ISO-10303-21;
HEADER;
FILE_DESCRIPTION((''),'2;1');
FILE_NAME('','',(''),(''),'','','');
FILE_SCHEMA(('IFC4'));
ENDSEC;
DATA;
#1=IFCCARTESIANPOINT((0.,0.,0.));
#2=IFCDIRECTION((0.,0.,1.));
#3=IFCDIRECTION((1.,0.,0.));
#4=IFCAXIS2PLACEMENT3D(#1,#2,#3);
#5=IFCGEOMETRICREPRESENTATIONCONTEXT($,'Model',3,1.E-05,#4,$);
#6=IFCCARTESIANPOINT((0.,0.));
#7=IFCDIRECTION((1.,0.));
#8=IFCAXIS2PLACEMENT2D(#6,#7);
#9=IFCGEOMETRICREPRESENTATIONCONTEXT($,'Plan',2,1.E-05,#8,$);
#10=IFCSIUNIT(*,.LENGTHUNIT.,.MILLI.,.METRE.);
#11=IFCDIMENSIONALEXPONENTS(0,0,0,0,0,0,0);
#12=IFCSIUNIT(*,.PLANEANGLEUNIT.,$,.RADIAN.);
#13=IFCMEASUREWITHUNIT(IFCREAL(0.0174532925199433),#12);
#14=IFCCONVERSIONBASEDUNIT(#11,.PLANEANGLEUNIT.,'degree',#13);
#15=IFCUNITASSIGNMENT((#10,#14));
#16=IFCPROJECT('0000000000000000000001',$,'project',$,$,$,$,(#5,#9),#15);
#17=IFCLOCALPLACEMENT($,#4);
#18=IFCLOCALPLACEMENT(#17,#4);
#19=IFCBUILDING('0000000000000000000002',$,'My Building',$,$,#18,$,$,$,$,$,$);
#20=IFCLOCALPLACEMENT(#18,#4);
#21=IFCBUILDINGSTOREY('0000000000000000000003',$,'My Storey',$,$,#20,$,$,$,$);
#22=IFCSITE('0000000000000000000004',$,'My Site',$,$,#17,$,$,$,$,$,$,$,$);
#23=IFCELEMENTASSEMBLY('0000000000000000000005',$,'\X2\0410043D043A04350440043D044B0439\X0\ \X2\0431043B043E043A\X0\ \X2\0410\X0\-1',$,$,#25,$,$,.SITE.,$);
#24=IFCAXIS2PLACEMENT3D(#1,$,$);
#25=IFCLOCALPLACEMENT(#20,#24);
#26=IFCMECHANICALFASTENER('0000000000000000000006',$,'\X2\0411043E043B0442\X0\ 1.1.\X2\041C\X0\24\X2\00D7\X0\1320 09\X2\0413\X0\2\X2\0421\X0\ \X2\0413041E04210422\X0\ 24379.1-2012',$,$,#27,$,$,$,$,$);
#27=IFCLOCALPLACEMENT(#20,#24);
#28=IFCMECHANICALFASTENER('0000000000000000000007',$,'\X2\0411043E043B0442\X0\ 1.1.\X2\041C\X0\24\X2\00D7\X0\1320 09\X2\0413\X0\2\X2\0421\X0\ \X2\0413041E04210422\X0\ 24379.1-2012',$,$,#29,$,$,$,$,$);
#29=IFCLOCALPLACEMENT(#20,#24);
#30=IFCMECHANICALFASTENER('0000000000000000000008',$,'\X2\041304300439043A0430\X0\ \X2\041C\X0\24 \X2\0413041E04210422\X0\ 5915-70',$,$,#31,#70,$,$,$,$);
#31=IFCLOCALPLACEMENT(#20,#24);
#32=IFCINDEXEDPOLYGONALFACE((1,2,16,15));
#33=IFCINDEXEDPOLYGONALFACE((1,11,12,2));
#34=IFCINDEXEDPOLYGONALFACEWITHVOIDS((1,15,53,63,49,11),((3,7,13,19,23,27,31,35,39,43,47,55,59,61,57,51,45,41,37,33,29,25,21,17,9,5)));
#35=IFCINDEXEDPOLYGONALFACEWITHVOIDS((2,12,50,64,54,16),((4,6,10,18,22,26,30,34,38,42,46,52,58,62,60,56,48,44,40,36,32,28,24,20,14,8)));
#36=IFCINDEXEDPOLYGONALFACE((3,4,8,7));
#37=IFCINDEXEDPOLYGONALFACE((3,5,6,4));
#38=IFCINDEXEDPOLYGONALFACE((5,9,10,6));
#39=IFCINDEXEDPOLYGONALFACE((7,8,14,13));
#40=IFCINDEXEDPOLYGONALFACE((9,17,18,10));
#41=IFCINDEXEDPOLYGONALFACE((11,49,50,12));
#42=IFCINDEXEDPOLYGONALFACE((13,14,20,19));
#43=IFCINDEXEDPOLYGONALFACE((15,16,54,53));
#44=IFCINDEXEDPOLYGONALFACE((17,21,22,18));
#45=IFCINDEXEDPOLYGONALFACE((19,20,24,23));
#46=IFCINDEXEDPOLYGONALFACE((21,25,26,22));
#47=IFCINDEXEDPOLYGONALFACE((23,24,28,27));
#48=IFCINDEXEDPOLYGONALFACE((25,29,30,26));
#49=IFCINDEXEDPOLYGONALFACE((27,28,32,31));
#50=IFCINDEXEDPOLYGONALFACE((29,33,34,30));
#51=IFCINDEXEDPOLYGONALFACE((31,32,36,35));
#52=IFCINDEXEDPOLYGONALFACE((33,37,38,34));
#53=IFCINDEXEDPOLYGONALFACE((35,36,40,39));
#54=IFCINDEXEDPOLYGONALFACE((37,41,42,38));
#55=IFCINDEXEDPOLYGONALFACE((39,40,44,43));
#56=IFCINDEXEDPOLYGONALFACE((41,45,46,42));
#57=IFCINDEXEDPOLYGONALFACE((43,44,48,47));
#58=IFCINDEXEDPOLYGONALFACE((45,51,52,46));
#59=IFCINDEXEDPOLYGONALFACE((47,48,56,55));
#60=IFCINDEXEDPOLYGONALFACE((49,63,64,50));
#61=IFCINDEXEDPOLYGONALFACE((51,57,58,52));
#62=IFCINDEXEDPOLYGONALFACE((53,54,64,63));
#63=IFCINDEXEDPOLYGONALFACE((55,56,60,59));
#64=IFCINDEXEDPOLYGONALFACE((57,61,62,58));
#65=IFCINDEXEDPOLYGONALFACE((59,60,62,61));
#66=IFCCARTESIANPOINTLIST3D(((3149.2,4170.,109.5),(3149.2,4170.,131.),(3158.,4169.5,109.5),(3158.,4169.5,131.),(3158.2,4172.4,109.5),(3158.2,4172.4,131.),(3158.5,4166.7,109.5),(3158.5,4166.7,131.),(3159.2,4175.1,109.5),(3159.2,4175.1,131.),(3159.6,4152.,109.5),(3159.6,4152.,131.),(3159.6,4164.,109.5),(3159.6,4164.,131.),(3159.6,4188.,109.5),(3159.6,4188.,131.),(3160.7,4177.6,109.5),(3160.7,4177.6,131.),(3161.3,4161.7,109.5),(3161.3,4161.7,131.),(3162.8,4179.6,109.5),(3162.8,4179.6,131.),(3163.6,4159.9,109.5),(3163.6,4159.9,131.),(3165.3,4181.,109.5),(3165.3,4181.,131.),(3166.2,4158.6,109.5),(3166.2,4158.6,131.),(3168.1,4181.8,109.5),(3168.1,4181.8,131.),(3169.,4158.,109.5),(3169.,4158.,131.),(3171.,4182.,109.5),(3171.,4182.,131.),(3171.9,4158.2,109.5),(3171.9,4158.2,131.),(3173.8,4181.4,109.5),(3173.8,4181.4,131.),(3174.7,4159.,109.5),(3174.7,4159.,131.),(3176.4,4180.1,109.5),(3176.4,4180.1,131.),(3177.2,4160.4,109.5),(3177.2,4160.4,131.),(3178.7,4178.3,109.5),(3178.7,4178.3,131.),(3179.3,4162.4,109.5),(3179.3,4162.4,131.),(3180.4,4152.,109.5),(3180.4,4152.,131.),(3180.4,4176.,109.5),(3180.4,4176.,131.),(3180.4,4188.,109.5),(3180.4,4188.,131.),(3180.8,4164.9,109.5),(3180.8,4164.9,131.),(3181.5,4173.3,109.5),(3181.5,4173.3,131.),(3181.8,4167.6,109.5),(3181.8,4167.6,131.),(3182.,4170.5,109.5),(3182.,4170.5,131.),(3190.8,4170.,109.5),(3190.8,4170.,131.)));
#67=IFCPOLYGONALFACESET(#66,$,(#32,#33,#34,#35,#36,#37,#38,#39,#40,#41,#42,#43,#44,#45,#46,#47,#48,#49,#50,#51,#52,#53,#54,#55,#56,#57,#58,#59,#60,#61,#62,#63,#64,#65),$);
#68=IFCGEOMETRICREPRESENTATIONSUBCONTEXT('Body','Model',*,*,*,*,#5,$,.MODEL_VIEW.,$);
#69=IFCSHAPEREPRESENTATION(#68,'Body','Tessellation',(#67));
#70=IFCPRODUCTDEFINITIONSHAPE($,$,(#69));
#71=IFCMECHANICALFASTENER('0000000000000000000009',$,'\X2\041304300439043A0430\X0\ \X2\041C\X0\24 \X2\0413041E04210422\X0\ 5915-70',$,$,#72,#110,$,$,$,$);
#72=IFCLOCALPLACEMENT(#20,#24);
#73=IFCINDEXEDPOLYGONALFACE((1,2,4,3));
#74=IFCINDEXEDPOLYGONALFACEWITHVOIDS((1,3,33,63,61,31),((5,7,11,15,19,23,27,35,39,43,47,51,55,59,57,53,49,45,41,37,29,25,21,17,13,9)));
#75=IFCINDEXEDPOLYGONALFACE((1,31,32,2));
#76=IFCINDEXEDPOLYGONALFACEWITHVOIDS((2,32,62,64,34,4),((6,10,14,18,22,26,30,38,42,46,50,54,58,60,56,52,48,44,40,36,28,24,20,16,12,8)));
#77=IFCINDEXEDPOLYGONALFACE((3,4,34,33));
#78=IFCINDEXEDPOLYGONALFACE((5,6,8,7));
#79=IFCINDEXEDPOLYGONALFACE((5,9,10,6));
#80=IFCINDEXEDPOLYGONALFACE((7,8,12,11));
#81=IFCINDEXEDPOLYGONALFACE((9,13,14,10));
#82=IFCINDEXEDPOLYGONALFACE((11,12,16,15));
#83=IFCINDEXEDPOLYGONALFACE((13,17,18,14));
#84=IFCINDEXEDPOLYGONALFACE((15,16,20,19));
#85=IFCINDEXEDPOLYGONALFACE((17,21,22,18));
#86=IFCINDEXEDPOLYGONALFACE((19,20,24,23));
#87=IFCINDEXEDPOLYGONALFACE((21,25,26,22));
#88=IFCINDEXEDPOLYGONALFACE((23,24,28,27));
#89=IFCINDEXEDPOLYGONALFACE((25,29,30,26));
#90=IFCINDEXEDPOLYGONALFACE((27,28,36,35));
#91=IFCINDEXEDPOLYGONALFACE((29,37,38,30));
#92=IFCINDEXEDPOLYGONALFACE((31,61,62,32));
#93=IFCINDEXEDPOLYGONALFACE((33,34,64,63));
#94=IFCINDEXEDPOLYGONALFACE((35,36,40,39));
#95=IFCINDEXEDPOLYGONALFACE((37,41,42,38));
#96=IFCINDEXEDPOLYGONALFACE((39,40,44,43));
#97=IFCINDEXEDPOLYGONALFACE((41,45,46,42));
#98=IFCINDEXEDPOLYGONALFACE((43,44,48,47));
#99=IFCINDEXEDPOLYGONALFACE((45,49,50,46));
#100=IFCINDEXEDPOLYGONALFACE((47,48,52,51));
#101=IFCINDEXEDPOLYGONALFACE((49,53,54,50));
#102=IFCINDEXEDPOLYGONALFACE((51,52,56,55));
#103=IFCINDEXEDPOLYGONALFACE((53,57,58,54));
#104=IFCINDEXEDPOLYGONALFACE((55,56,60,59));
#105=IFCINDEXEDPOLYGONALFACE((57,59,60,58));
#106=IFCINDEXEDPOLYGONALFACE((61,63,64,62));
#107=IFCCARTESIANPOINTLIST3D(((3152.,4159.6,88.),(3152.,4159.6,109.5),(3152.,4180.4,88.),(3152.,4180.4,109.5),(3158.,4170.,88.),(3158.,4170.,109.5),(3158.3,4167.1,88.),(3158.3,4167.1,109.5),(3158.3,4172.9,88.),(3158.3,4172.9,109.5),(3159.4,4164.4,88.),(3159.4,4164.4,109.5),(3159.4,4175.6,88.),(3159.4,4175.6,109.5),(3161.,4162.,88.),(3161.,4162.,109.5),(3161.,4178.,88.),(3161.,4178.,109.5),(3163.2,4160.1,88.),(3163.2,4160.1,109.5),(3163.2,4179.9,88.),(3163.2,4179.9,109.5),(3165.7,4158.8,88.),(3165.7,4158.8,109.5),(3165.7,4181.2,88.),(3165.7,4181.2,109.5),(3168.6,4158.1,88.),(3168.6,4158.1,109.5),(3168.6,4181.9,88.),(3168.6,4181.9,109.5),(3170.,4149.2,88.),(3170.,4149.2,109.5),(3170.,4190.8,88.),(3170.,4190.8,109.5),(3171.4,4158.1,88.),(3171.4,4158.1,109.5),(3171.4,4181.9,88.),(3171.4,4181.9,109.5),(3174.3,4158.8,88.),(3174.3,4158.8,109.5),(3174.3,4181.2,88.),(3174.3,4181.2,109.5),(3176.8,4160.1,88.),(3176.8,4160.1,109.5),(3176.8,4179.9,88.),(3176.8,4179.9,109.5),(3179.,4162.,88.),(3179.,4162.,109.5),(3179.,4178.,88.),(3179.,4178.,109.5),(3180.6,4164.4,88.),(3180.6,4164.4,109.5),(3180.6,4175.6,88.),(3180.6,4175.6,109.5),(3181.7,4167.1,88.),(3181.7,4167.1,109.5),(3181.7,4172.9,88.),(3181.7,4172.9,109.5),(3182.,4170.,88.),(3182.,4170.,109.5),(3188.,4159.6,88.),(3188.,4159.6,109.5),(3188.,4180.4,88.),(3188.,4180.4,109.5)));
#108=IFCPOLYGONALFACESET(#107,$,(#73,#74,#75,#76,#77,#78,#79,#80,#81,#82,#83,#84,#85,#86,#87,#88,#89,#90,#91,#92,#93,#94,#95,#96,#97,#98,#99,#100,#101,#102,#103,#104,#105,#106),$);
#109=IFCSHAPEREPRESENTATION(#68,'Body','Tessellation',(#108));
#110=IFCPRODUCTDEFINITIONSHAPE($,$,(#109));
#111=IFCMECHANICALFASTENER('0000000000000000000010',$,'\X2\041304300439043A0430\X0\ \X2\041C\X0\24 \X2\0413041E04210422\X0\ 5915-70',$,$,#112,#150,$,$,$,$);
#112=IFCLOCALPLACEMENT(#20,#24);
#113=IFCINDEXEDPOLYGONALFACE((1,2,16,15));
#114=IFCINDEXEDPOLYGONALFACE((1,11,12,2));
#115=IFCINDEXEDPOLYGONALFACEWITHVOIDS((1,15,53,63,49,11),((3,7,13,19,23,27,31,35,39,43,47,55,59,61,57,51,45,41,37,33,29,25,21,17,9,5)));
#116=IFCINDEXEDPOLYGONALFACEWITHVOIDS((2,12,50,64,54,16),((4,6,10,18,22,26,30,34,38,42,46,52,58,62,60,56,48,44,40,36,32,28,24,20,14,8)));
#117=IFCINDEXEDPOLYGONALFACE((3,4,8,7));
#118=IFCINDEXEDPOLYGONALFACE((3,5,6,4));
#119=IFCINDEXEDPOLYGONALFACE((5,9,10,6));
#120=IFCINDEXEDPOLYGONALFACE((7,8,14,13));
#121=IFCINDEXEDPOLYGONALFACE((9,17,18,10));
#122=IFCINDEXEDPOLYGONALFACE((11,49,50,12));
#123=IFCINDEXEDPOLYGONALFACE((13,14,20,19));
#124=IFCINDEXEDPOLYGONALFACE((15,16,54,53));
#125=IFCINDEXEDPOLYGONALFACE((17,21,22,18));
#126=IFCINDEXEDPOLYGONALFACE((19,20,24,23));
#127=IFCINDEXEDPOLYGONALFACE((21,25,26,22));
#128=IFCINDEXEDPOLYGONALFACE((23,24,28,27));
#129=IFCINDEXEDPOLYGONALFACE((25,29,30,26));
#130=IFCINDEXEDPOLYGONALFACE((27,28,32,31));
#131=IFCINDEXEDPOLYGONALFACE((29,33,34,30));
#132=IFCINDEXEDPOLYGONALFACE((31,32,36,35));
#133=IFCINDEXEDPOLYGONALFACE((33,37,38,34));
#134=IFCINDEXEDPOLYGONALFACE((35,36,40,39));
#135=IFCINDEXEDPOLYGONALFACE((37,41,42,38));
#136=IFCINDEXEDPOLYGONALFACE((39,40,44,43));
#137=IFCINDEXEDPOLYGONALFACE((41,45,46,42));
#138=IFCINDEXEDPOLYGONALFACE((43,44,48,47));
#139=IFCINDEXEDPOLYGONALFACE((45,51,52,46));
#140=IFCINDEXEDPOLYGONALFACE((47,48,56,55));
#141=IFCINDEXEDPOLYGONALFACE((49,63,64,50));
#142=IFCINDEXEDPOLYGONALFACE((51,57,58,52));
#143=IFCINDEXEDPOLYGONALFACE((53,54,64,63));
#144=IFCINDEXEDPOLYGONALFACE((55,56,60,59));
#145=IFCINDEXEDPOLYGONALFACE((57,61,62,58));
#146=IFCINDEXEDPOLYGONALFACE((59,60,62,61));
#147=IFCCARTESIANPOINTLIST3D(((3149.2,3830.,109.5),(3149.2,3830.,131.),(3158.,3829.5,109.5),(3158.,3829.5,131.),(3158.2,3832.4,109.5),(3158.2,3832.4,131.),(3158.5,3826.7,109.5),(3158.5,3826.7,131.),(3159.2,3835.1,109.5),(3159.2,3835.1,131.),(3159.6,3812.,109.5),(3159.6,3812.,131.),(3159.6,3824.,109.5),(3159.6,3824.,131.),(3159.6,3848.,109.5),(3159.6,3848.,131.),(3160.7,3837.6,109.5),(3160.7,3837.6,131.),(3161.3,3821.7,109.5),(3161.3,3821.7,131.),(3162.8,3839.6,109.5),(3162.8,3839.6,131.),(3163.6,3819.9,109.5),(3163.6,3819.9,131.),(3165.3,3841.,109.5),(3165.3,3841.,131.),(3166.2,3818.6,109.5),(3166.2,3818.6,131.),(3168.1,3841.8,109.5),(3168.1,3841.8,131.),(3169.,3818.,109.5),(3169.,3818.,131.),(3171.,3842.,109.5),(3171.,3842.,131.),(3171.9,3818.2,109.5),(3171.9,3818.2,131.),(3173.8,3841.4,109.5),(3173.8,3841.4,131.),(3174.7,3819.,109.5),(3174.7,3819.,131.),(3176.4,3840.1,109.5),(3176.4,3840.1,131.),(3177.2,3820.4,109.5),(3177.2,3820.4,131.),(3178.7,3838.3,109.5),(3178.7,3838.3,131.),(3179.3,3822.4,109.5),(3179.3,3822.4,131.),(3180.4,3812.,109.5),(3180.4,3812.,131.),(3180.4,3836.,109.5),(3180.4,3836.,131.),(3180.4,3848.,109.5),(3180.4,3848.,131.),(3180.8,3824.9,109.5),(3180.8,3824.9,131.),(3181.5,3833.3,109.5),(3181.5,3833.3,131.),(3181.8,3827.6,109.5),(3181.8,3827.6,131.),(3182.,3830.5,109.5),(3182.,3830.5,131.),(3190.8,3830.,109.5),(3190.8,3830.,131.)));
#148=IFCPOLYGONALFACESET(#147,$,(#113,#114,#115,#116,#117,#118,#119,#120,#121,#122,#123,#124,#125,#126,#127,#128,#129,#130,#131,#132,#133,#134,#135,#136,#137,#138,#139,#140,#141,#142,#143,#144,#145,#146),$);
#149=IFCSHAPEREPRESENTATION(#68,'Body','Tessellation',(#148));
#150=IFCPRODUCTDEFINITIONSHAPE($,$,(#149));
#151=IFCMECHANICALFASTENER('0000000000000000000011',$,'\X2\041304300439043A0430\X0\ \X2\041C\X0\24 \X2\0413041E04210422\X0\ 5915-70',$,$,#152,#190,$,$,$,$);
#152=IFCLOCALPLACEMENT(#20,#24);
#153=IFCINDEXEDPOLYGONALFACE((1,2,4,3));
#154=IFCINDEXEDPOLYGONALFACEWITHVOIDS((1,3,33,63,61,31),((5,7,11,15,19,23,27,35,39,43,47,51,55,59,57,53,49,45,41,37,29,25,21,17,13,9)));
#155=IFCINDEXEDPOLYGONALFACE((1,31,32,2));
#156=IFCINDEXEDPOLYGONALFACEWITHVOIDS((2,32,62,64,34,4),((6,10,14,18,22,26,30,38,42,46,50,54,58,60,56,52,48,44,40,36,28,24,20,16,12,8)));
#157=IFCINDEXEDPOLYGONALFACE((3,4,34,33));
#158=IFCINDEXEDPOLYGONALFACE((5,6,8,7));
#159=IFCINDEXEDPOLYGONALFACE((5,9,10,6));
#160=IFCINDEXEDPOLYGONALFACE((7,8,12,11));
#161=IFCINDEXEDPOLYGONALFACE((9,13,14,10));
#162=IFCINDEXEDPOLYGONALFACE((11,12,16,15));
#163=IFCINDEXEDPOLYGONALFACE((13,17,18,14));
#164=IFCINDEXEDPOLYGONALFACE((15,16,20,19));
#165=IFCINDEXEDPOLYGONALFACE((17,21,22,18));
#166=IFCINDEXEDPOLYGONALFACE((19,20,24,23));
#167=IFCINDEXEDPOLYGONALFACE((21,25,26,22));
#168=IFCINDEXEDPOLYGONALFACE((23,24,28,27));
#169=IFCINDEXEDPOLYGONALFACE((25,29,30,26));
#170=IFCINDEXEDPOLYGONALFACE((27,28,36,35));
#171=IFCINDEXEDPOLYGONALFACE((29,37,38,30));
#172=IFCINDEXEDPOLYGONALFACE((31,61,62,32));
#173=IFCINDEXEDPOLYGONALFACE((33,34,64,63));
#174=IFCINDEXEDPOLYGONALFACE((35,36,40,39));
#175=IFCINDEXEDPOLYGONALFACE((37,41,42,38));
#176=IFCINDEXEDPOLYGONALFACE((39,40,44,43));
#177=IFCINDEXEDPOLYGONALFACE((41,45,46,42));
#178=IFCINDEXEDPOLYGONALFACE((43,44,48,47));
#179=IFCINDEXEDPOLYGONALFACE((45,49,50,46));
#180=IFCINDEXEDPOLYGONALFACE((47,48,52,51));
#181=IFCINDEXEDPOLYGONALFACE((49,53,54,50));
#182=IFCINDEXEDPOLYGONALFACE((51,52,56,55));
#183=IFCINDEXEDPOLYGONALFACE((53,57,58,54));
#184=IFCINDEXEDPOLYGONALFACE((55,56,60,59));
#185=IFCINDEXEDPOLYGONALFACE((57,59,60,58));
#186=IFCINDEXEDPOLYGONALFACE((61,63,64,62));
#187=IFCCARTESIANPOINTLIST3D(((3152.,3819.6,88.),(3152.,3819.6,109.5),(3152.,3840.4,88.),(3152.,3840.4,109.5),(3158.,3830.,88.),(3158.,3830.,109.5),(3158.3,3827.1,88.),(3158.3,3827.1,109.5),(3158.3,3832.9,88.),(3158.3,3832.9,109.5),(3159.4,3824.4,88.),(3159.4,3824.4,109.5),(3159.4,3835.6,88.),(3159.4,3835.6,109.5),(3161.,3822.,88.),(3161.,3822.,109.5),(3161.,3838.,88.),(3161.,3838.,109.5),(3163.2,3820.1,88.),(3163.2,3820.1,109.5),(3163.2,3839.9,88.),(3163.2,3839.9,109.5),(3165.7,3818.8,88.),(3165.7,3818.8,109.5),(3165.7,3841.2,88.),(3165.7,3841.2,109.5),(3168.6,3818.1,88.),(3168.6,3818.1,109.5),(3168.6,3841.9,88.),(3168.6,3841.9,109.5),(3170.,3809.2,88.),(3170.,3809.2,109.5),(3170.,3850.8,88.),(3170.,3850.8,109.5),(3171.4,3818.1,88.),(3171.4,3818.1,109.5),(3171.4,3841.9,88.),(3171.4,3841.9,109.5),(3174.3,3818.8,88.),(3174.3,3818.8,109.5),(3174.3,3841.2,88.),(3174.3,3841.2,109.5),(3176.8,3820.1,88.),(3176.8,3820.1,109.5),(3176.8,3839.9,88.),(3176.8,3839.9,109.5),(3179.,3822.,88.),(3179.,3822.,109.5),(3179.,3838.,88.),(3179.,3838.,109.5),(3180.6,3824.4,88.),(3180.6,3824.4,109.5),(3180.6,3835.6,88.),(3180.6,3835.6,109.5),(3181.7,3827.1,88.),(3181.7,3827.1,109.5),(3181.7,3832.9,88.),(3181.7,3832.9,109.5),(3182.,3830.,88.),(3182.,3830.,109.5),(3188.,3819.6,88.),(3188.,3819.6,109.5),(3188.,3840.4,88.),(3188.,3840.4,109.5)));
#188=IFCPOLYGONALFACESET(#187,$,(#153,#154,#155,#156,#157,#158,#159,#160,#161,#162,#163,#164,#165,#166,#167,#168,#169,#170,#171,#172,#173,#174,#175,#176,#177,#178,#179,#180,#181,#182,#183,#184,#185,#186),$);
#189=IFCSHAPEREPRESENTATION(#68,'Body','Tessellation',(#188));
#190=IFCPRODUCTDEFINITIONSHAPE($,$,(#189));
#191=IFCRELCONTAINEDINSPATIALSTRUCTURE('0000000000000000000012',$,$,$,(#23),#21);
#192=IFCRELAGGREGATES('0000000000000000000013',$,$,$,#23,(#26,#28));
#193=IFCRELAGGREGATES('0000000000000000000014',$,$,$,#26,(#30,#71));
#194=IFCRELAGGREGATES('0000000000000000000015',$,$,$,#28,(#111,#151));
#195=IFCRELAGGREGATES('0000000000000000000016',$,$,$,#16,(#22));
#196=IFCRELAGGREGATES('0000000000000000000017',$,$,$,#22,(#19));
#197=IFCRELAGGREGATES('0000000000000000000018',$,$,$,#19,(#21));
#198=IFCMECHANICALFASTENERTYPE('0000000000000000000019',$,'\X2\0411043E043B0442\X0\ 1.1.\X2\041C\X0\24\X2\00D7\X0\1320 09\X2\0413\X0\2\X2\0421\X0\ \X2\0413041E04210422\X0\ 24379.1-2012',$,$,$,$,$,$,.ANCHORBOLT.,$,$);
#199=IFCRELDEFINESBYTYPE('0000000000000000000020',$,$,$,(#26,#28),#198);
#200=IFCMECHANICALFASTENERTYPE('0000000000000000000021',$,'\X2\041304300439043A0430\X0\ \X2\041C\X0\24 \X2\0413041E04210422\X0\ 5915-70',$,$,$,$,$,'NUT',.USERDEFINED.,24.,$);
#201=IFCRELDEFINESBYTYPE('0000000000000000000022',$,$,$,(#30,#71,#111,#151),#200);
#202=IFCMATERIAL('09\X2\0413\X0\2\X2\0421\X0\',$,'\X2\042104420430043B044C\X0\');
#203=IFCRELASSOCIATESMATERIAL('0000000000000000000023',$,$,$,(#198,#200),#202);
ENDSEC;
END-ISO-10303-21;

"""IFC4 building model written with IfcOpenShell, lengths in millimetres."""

from ifc_helpers import new_model, entity, si_unit, converted_unit, frame, origin_with_axes, origin_2d_with_axis, place, context, subcontext, project, spatial, polyline, outline, extrude, source, transform, mapped, material, type_object, type_shapes, element, aggregate, save


model = new_model("IFC4")

# Units and contexts
model_context = context("Model", 3, precision=1e-05, world=origin_with_axes())
plan_context = context("Plan", 2, precision=1e-05, world=origin_2d_with_axis())
body_context = subcontext(model_context, "Body", "Model", "MODEL_VIEW")
ifc_project = project(units=[si_unit("LENGTHUNIT", "METRE", prefix="MILLI"), converted_unit("PLANEANGLEUNIT", "degree", entity("IfcReal", 0.0174532925199433), si_unit("PLANEANGLEUNIT", "RADIAN"), dimensions=[0, 0, 0, 0, 0, 0, 0])], contexts=[model_context, plan_context])

# Site, building, storey
site_placement = place(None, origin_with_axes())
site = spatial("IfcSite", under=ifc_project, at=site_placement, Name="My Site")
building_placement = place(site_placement, origin_with_axes())
building = spatial("IfcBuilding", under=site, at=building_placement, Name="My Building")
storey_placement = place(building_placement, origin_with_axes())
storey = spatial("IfcBuildingStorey", under=building, at=storey_placement, Name="My Storey")

# Element assembly, mechanical fasteners
ifc_material_1 = material(Name="09Г2С", Category="Сталь")
mechanical_fastener_type_1 = type_object("IfcMechanicalFastenerType", Name="Болт 1.1.М24×1320 09Г2С ГОСТ 24379.1-2012", PredefinedType="ANCHORBOLT", material=ifc_material_1)
assembly_1_placement = place(storey_placement, frame((3000.0, 4000.0, 0.0), z_axis=(0.0, 0.0, 1.0), x_axis=(1.0, 0.0, 0.0)))
assembly_1 = element("IfcElementAssembly", 1, at=assembly_1_placement, inside=storey, Name="Анкерный блок А-1", AssemblyPlace="SITE")
mechanical_fastener_1_placement = place(assembly_1_placement, frame((170.0, 170.0, 0.0), z_axis=(0.0, 0.0, 1.0), x_axis=(-1.0, 0.0, 0.0)))
mechanical_fastener_1 = element("IfcMechanicalFastener", 2, at=mechanical_fastener_1_placement, type_object=mechanical_fastener_type_1, Name="Болт 1.1.М24×1320 09Г2С ГОСТ 24379.1-2012")
mechanical_fastener_2_placement = place(assembly_1_placement, frame((170.0, -170.0, 0.0), z_axis=(0.0, 0.0, 1.0), x_axis=(1.0, 0.0, 0.0)))
mechanical_fastener_2 = element("IfcMechanicalFastener", 3, at=mechanical_fastener_2_placement, type_object=mechanical_fastener_type_1, Name="Болт 1.1.М24×1320 09Г2С ГОСТ 24379.1-2012")
aggregate(assembly_1, [mechanical_fastener_1, mechanical_fastener_2])

# Mechanical fasteners
mechanical_fastener_type_2 = type_object("IfcMechanicalFastenerType", Name="Гайка М24 ГОСТ 5915-70", ElementType="NUT", NominalDiameter=24.0, PredefinedType="USERDEFINED", material=ifc_material_1)
shared_shape_1 = source(origin_with_axes(), body_context, "Body", "SweptSolid", [
    extrude(outline(polyline([(-10.4, -18.0), (10.4, -18.0), (20.8, 0.0), (10.4, 18.0), (-10.4, 18.0), (-20.8, 0.0), (-10.4, -18.0)]), holes=[polyline([(-8.0, 9.0), (-5.6, 10.6), (-2.9, 11.7), (0.0, 12.0), (2.9, 11.7), (5.6, 10.6), (8.0, 9.0), (9.9, 6.8), (11.2, 4.3), (11.9, 1.4), (11.9, -1.4), (11.2, -4.3), (9.9, -6.8), (8.0, -9.0), (5.6, -10.6), (2.9, -11.7), (0.0, -12.0), (-2.9, -11.7), (-5.6, -10.6), (-8.0, -9.0), (-9.9, -6.8), (-11.2, -4.3), (-11.9, -1.4), (-11.9, 1.4), (-11.2, 4.3), (-9.9, 6.8), (-8.0, 9.0)])]), frame((0.0, 0.0, 0.0), z_axis=(0.0, 0.0, 1.0), x_axis=(0.0, 1.0, 0.0)), (0.0, 0.0, 1.0), 21.5),
])
type_shapes(mechanical_fastener_type_2, [shared_shape_1])
mechanical_fastener_3_placement = place(mechanical_fastener_1_placement, frame((0.0, 0.0, 109.5), z_axis=(0.0, 0.0, 1.0), x_axis=(0.866025, 0.5, 0.0)))
mechanical_fastener_3 = element("IfcMechanicalFastener", 4, at=mechanical_fastener_3_placement, type_object=mechanical_fastener_type_2, Name="Гайка М24 ГОСТ 5915-70", context=body_context, shape_type="MappedRepresentation", body=[
    mapped(shared_shape_1, transform((0.0, 0.0, 0.0), x_axis=(1.0, 0.0, 0.0), y_axis=(0.0, 1.0, 0.0), z_axis=(0.0, 0.0, 1.0), scale=1.0)),
])
mechanical_fastener_4_placement = place(mechanical_fastener_1_placement, frame((0.0, 0.0, 88.0), z_axis=(0.0, 0.0, 1.0), x_axis=(1.0, 0.0, 0.0)))
mechanical_fastener_4 = element("IfcMechanicalFastener", 5, at=mechanical_fastener_4_placement, type_object=mechanical_fastener_type_2, Name="Гайка М24 ГОСТ 5915-70", context=body_context, shape_type="MappedRepresentation", body=[
    mapped(shared_shape_1, transform((0.0, 0.0, 0.0), x_axis=(1.0, 0.0, 0.0), y_axis=(0.0, 1.0, 0.0), z_axis=(0.0, 0.0, 1.0), scale=1.0)),
])
mechanical_fastener_5_placement = place(mechanical_fastener_2_placement, frame((0.0, 0.0, 109.5), z_axis=(0.0, 0.0, 1.0), x_axis=(0.866025, 0.5, 0.0)))
mechanical_fastener_5 = element("IfcMechanicalFastener", 6, at=mechanical_fastener_5_placement, type_object=mechanical_fastener_type_2, Name="Гайка М24 ГОСТ 5915-70", context=body_context, shape_type="MappedRepresentation", body=[
    mapped(shared_shape_1, transform((0.0, 0.0, 0.0), x_axis=(1.0, 0.0, 0.0), y_axis=(0.0, 1.0, 0.0), z_axis=(0.0, 0.0, 1.0), scale=1.0)),
])
mechanical_fastener_6_placement = place(mechanical_fastener_2_placement, frame((0.0, 0.0, 88.0), z_axis=(0.0, 0.0, 1.0), x_axis=(1.0, 0.0, 0.0)))
mechanical_fastener_6 = element("IfcMechanicalFastener", 7, at=mechanical_fastener_6_placement, type_object=mechanical_fastener_type_2, Name="Гайка М24 ГОСТ 5915-70", context=body_context, shape_type="MappedRepresentation", body=[
    mapped(shared_shape_1, transform((0.0, 0.0, 0.0), x_axis=(1.0, 0.0, 0.0), y_axis=(0.0, 1.0, 0.0), z_axis=(0.0, 0.0, 1.0), scale=1.0)),
])
aggregate(mechanical_fastener_1, [mechanical_fastener_3, mechanical_fastener_4])
aggregate(mechanical_fastener_2, [mechanical_fastener_5, mechanical_fastener_6])

save(model, "model.ifc")
